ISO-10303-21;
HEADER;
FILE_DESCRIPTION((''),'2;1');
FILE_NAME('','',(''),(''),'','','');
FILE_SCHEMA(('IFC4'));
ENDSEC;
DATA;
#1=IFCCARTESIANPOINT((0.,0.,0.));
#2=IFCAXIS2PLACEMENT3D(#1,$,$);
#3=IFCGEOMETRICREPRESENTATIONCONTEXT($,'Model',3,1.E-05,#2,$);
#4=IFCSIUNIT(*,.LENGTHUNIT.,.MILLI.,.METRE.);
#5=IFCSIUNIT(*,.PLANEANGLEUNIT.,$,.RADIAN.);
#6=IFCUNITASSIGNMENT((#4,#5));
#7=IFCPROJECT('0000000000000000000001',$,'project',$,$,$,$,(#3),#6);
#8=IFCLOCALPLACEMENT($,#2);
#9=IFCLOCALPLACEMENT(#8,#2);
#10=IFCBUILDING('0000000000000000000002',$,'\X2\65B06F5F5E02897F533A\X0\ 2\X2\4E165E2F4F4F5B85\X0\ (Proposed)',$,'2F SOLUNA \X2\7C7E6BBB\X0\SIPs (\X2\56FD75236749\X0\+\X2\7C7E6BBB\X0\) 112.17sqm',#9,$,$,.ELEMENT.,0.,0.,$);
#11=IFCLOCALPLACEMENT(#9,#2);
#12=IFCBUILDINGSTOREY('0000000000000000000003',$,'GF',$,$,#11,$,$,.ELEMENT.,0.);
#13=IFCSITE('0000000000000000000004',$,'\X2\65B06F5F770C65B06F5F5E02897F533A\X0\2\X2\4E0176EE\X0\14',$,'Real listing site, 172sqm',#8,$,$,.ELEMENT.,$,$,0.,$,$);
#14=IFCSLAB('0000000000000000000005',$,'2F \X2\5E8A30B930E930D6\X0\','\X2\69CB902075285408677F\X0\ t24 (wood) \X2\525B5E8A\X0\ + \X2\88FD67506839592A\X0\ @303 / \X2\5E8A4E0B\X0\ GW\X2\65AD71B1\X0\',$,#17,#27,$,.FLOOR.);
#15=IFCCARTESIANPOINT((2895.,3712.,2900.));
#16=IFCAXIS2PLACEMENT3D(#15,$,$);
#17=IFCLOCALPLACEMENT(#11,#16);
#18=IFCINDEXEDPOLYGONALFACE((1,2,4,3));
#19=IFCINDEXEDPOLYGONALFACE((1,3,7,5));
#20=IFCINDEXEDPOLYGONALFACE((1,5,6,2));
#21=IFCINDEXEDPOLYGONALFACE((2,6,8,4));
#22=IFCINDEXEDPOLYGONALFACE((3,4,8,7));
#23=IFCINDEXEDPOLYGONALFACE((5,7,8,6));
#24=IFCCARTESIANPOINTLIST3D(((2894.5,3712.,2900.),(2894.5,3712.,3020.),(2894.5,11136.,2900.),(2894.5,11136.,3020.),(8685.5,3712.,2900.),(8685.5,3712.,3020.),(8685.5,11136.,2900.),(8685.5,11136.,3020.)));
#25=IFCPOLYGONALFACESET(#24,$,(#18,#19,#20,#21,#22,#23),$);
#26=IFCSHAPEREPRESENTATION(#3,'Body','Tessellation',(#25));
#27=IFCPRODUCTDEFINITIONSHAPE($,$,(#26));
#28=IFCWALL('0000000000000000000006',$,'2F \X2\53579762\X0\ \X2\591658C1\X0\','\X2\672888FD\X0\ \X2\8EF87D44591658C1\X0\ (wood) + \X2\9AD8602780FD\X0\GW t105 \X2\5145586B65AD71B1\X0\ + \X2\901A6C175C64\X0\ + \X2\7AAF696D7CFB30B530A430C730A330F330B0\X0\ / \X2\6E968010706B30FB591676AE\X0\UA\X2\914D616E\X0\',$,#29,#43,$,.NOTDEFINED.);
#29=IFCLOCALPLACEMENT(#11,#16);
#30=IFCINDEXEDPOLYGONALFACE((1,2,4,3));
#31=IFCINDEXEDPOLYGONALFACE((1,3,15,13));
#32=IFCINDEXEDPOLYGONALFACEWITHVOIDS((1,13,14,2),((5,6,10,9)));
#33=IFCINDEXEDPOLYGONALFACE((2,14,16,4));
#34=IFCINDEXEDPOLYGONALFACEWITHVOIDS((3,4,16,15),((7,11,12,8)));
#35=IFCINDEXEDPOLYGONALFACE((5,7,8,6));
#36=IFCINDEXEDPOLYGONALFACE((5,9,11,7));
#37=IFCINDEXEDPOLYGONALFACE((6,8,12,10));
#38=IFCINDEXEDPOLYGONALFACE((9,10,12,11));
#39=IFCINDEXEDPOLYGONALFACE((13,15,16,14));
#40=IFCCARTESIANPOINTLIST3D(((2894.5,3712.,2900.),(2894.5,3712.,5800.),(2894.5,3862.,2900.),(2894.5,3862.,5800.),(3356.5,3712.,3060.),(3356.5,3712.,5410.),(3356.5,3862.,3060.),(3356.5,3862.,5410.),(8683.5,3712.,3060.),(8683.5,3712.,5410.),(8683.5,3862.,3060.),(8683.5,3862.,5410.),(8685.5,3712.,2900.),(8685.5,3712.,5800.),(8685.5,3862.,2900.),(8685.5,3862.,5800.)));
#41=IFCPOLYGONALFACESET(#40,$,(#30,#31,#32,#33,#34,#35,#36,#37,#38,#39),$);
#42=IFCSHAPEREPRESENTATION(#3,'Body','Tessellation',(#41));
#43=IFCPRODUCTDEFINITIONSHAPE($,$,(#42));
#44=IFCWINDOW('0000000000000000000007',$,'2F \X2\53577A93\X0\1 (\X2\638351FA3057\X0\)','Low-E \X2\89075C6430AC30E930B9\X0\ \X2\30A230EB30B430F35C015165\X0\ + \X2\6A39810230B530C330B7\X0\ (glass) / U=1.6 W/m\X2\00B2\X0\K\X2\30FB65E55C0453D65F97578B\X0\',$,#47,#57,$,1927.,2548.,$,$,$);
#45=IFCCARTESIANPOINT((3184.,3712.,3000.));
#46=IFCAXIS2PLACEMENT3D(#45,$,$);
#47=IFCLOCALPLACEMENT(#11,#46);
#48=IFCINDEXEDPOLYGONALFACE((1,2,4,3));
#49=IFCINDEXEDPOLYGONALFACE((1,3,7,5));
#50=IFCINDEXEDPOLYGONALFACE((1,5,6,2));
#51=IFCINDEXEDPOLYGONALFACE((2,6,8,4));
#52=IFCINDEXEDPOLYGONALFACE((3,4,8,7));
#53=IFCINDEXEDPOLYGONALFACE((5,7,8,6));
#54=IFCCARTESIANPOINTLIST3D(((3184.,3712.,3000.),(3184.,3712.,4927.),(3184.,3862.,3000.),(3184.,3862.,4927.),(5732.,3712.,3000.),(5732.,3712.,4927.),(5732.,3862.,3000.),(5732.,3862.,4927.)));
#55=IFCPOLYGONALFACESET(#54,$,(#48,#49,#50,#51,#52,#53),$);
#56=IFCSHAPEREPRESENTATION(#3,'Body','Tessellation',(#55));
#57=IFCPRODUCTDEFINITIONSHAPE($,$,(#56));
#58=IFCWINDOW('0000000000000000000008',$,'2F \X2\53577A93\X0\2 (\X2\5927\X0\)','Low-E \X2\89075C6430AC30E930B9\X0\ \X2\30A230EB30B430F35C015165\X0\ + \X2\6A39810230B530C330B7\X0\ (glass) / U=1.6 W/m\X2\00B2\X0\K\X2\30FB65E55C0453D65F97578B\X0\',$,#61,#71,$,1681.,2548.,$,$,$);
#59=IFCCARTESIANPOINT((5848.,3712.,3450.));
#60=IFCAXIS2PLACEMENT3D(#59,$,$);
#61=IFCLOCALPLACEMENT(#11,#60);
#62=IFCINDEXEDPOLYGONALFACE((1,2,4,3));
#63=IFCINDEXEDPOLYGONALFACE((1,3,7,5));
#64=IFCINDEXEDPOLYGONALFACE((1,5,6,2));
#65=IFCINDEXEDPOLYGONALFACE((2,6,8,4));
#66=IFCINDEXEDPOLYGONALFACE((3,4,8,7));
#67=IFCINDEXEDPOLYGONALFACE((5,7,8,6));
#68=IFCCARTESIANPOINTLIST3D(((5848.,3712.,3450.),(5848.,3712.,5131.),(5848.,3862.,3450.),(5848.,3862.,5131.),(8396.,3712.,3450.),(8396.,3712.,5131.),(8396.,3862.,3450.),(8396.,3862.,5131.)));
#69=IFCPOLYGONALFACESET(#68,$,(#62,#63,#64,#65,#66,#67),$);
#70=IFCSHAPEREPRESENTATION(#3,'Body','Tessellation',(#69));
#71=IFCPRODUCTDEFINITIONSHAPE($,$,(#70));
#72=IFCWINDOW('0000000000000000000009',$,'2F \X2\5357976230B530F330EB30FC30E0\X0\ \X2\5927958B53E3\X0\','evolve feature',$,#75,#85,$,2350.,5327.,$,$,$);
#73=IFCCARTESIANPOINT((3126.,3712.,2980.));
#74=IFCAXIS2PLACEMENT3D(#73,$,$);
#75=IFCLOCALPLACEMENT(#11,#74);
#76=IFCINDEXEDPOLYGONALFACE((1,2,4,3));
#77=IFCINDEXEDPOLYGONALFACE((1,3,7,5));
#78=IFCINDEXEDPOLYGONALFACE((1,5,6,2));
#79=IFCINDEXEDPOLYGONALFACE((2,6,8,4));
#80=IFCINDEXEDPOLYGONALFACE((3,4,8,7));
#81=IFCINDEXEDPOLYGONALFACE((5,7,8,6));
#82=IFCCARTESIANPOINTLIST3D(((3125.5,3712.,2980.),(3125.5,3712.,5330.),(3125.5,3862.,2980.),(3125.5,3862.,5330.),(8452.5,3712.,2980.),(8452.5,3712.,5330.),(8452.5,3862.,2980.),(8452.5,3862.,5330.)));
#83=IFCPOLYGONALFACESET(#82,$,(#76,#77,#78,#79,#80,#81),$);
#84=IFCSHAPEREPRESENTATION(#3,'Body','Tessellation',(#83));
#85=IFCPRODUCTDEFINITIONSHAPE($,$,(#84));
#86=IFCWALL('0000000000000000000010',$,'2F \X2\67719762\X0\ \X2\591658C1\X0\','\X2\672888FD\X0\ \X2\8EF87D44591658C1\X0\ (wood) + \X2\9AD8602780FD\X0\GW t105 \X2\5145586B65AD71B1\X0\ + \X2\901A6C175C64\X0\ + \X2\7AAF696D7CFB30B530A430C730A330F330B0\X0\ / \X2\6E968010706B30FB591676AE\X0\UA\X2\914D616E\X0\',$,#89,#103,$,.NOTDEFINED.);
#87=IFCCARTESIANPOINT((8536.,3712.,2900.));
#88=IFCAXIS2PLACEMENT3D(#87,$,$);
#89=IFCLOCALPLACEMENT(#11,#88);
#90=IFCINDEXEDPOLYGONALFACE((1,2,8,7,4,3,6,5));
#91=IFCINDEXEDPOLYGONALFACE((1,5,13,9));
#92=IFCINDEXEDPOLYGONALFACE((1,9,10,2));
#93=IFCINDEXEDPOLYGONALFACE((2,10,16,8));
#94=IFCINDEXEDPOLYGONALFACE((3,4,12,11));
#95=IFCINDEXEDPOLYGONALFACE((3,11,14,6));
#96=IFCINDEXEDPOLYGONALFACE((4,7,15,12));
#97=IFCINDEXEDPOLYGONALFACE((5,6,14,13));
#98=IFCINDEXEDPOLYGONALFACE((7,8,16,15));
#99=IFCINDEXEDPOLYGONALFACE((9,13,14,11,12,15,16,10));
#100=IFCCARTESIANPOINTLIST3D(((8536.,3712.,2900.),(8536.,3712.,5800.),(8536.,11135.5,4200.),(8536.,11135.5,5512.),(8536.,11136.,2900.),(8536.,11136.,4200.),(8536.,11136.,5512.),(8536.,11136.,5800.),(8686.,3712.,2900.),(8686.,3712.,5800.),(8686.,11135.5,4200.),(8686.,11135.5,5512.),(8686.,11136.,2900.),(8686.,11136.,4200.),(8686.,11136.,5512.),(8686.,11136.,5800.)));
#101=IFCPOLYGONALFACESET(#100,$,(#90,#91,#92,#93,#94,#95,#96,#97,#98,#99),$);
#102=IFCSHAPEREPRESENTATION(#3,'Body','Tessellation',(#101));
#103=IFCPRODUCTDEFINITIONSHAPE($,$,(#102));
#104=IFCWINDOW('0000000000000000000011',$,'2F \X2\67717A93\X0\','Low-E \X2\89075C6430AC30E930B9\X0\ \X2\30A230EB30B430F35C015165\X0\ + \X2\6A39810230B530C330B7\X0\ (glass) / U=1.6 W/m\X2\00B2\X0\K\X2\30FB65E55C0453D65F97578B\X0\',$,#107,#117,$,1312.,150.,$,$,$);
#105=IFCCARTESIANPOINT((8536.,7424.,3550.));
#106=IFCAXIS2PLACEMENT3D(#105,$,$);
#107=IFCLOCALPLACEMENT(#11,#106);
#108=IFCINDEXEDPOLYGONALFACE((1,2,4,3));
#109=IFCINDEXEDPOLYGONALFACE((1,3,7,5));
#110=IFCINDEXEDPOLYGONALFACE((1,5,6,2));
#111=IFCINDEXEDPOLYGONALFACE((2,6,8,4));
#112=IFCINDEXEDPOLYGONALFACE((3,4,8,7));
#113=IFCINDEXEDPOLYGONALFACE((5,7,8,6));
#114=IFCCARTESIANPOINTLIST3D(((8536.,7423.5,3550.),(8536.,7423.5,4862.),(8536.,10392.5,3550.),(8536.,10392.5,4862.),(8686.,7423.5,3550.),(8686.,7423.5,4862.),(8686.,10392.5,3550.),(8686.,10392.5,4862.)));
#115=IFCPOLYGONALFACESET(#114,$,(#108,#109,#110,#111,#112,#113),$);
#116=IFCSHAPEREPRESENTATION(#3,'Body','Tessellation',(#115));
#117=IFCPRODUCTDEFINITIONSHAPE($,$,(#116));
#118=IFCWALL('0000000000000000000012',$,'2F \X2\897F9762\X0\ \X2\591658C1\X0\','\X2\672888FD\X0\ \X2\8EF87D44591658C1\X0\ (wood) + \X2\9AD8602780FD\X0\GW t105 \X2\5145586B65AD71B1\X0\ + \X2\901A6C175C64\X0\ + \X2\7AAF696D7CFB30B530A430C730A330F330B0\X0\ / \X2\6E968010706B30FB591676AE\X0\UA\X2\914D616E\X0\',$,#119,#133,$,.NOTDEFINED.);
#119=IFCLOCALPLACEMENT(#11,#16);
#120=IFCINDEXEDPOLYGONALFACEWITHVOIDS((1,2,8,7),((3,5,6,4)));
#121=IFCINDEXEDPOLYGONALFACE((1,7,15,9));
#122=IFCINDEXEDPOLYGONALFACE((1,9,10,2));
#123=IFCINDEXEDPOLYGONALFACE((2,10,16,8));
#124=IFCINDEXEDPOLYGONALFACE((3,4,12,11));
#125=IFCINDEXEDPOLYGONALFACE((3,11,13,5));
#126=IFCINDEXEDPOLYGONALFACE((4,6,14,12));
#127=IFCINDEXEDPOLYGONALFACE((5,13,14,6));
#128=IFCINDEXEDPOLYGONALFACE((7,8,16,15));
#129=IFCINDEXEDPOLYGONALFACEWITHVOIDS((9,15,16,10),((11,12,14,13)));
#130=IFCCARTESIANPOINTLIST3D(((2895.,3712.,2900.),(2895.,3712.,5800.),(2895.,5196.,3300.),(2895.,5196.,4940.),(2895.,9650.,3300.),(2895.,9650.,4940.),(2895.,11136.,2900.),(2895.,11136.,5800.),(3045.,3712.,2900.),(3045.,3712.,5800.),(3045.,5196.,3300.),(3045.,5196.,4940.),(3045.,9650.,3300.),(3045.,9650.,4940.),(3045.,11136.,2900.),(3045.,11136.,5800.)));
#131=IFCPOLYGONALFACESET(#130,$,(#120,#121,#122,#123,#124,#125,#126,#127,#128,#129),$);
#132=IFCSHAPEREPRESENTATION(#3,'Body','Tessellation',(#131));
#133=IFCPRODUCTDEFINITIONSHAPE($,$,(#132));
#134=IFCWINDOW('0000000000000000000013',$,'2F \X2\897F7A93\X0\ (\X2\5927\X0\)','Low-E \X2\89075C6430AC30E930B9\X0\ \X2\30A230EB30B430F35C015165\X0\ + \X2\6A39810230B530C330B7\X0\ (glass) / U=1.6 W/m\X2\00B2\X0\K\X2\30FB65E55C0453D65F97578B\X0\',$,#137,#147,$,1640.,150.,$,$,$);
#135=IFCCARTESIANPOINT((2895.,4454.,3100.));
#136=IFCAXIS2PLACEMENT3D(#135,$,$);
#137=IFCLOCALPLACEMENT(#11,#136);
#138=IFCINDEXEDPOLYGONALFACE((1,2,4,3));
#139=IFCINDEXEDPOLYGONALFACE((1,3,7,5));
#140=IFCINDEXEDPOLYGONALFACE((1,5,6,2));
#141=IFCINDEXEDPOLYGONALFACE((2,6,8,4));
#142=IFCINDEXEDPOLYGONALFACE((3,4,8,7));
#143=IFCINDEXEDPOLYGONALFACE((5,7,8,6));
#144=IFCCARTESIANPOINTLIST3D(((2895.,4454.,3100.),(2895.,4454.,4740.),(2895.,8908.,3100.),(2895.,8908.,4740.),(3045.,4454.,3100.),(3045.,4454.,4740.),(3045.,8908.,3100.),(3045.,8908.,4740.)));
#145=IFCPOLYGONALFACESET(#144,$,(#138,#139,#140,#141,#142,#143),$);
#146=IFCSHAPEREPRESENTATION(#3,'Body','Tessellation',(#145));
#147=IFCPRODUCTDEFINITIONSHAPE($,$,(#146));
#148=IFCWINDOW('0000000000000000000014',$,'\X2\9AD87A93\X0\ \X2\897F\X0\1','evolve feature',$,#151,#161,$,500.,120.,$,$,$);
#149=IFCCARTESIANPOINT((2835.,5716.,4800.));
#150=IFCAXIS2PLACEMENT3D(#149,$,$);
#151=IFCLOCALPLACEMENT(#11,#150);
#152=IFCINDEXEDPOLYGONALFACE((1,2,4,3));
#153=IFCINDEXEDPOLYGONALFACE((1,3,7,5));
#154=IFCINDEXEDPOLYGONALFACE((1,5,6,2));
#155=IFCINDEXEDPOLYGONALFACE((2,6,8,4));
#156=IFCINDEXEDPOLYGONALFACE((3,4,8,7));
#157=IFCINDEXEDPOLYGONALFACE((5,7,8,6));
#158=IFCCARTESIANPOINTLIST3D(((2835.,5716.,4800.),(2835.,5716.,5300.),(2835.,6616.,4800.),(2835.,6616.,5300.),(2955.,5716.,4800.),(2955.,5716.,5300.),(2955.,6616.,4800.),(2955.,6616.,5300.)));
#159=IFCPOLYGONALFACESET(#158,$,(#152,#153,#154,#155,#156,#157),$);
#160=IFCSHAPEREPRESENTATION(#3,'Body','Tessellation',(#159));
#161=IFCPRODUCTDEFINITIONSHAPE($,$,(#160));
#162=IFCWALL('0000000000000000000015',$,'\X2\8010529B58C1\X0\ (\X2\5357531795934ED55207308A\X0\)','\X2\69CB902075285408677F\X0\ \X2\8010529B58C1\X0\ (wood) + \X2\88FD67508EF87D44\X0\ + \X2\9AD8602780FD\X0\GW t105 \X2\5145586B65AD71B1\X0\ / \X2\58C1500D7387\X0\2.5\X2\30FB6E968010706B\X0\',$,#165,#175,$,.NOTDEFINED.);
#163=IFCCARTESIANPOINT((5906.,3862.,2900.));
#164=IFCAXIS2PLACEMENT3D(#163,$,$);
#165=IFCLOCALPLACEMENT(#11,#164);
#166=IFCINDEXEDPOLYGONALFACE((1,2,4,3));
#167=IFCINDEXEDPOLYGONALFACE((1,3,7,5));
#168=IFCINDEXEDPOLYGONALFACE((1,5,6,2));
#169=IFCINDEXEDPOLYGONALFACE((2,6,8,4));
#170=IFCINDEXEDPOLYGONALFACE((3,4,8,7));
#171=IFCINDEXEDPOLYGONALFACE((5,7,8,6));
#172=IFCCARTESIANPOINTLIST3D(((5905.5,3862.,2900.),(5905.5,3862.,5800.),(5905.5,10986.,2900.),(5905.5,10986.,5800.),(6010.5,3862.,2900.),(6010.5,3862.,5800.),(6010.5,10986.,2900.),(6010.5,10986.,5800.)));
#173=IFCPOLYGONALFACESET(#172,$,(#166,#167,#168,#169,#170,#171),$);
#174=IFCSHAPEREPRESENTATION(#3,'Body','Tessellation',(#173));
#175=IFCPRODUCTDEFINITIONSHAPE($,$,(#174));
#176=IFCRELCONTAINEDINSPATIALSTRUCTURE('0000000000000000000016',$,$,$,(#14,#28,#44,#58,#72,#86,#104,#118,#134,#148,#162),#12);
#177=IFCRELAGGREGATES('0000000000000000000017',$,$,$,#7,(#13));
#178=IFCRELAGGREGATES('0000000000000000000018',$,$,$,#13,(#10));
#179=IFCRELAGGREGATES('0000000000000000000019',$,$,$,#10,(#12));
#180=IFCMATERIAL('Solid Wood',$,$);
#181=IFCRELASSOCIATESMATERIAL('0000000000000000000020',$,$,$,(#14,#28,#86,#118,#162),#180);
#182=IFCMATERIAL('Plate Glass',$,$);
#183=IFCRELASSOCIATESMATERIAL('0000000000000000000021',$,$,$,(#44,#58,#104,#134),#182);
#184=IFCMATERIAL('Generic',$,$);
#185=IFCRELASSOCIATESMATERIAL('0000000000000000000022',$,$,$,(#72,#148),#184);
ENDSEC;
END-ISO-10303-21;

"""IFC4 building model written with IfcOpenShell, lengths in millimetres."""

from ifc_helpers import new_model, si_unit, frame, frame_2d, origin, place, context, project, spatial, rectangle, extrude, material, element, fill, save


model = new_model("IFC4")

# Units and contexts
model_context = context("Model", 3, precision=1e-05, world=origin())
ifc_project = project(units=[si_unit("LENGTHUNIT", "METRE", prefix="MILLI"), si_unit("PLANEANGLEUNIT", "RADIAN")], contexts=[model_context])

# Site, building, storey
site_placement = place(None, origin())
site = spatial("IfcSite", under=ifc_project, at=site_placement, Name="新潟県新潟市西区2丁目14", ObjectType="Real listing site, 172sqm", CompositionType="ELEMENT", RefElevation=0.0)
building_placement = place(site_placement, origin())
building = spatial("IfcBuilding", under=site, at=building_placement, Name="新潟市西区 2世帯住宅 (Proposed)", ObjectType="2F SOLUNA 籾殻SIPs (国産杉+籾殻) 112.17sqm", CompositionType="ELEMENT", ElevationOfRefHeight=0.0, ElevationOfTerrain=0.0)
storey_placement = place(building_placement, origin())
storey = spatial("IfcBuildingStorey", under=building, at=storey_placement, Name="GF", CompositionType="ELEMENT", Elevation=0.0)

# Slab
ifc_material_1 = material(Name="Solid Wood")
slab_placement = place(storey_placement, frame((2895.0, 3712.0, 2900.0)))
element("IfcSlab", 1, at=slab_placement, inside=storey, material=ifc_material_1, Name="2F 床スラブ", Description="構造用合板 t24 (wood) 剛床 + 製材根太 @303 / 床下 GW断熱", PredefinedType="FLOOR", context=model_context, shape_type="SweptSolid", body=[
    extrude(rectangle(XDim=5791.0, YDim=7424.0, at=frame_2d((2895.0, 3712.0))), frame((2895.0, 3712.0, 2900.0)), (0.0, 0.0, 1.0), 120.0),
])

# Wall, openings, windows
wall_1_placement = place(storey_placement, frame((2895.0, 3712.0, 2900.0)))
wall_1 = element("IfcWall", 2, at=wall_1_placement, inside=storey, material=ifc_material_1, Name="2F 南面 外壁", Description="木製 軸組外壁 (wood) + 高性能GW t105 充填断熱 + 通気層 + 窯業系サイディング / 準耐火・外皮UA配慮", PredefinedType="NOTDEFINED", context=model_context, shape_type="SweptSolid", body=[
    extrude(rectangle(XDim=5791.0, YDim=150.0, at=frame_2d((2895.0, 75.0))), frame((2895.0, 3712.0, 2900.0)), (0.0, 0.0, 1.0), 2900.0),
])
opening_1_placement = place(storey_placement, frame((3184.0, 3712.0, 3000.0)))
opening_1 = element("IfcOpeningElement", 3, at=opening_1_placement, cuts=wall_1, PredefinedType="NOTDEFINED", context=model_context, shape_type="SweptSolid", body=[
    extrude(rectangle(XDim=2548.0, YDim=150.0, at=frame_2d((1274.0, 75.0))), frame((3184.0, 3712.0, 3000.0)), (0.0, 0.0, 1.0), 1927.0),
])
opening_2_placement = place(storey_placement, frame((5848.0, 3712.0, 3450.0)))
opening_2 = element("IfcOpeningElement", 4, at=opening_2_placement, cuts=wall_1, PredefinedType="NOTDEFINED", context=model_context, shape_type="SweptSolid", body=[
    extrude(rectangle(XDim=2548.0, YDim=150.0, at=frame_2d((1274.0, 75.0))), frame((5848.0, 3712.0, 3450.0)), (0.0, 0.0, 1.0), 1681.0),
])
opening_3_placement = place(storey_placement, frame((3126.0, 3712.0, 2980.0)))
opening_3 = element("IfcOpeningElement", 5, at=opening_3_placement, cuts=wall_1, PredefinedType="NOTDEFINED", context=model_context, shape_type="SweptSolid", body=[
    extrude(rectangle(XDim=5327.0, YDim=150.0, at=frame_2d((2663.0, 75.0))), frame((3126.0, 3712.0, 2980.0)), (0.0, 0.0, 1.0), 2350.0),
])
ifc_material_2 = material(Name="Plate Glass")
window_1_placement = place(storey_placement, frame((3184.0, 3712.0, 3000.0)))
window_1 = element("IfcWindow", 6, at=window_1_placement, inside=storey, material=ifc_material_2, Name="2F 南窓1 (掃出し)", Description="Low-E 複層ガラス アルゴン封入 + 樹脂サッシ (glass) / U=1.6 W/m²K・日射取得型", OverallHeight=1927.0, OverallWidth=2548.0, context=model_context, shape_type="SweptSolid", body=[
    extrude(rectangle(XDim=2548.0, YDim=150.0, at=frame_2d((1274.0, 75.0))), frame((3184.0, 3712.0, 3000.0)), (0.0, 0.0, 1.0), 1927.0),
])
fill(opening_1, window_1)
window_2_placement = place(storey_placement, frame((5848.0, 3712.0, 3450.0)))
window_2 = element("IfcWindow", 7, at=window_2_placement, inside=storey, material=ifc_material_2, Name="2F 南窓2 (大)", Description="Low-E 複層ガラス アルゴン封入 + 樹脂サッシ (glass) / U=1.6 W/m²K・日射取得型", OverallHeight=1681.0, OverallWidth=2548.0, context=model_context, shape_type="SweptSolid", body=[
    extrude(rectangle(XDim=2548.0, YDim=150.0, at=frame_2d((1274.0, 75.0))), frame((5848.0, 3712.0, 3450.0)), (0.0, 0.0, 1.0), 1681.0),
])
fill(opening_2, window_2)
ifc_material_3 = material(Name="Generic")
window_3_placement = place(storey_placement, frame((3126.0, 3712.0, 2980.0)))
window_3 = element("IfcWindow", 8, at=window_3_placement, inside=storey, material=ifc_material_3, Name="2F 南面サンルーム 大開口", Description="evolve feature", OverallHeight=2350.0, OverallWidth=5327.0, context=model_context, shape_type="SweptSolid", body=[
    extrude(rectangle(XDim=5327.0, YDim=150.0, at=frame_2d((2663.0, 75.0))), frame((3126.0, 3712.0, 2980.0)), (0.0, 0.0, 1.0), 2350.0),
])
fill(opening_3, window_3)

# Wall, opening, window
wall_2_placement = place(storey_placement, frame((8536.0, 3712.0, 2900.0)))
wall_2 = element("IfcWall", 9, at=wall_2_placement, inside=storey, material=ifc_material_1, Name="2F 東面 外壁", Description="木製 軸組外壁 (wood) + 高性能GW t105 充填断熱 + 通気層 + 窯業系サイディング / 準耐火・外皮UA配慮", PredefinedType="NOTDEFINED", context=model_context, shape_type="SweptSolid", body=[
    extrude(rectangle(XDim=150.0, YDim=7424.0, at=frame_2d((75.0, 3712.0))), frame((8536.0, 3712.0, 2900.0)), (0.0, 0.0, 1.0), 2900.0),
])
opening_4_placement = place(storey_placement, frame((8536.0, 7424.0, 3550.0)))
opening_4 = element("IfcOpeningElement", 10, at=opening_4_placement, cuts=wall_2, PredefinedType="NOTDEFINED", context=model_context, shape_type="SweptSolid", body=[
    extrude(rectangle(XDim=150.0, YDim=2969.0, at=frame_2d((75.0, 1484.0))), frame((8536.0, 7424.0, 3550.0)), (0.0, 0.0, 1.0), 1312.0),
])
window_4_placement = place(storey_placement, frame((8536.0, 7424.0, 3550.0)))
window_4 = element("IfcWindow", 11, at=window_4_placement, inside=storey, material=ifc_material_2, Name="2F 東窓", Description="Low-E 複層ガラス アルゴン封入 + 樹脂サッシ (glass) / U=1.6 W/m²K・日射取得型", OverallHeight=1312.0, OverallWidth=150.0, context=model_context, shape_type="SweptSolid", body=[
    extrude(rectangle(XDim=150.0, YDim=2969.0, at=frame_2d((75.0, 1484.0))), frame((8536.0, 7424.0, 3550.0)), (0.0, 0.0, 1.0), 1312.0),
])
fill(opening_4, window_4)

# Wall, openings, windows
wall_3_placement = place(storey_placement, frame((2895.0, 3712.0, 2900.0)))
wall_3 = element("IfcWall", 12, at=wall_3_placement, inside=storey, material=ifc_material_1, Name="2F 西面 外壁", Description="木製 軸組外壁 (wood) + 高性能GW t105 充填断熱 + 通気層 + 窯業系サイディング / 準耐火・外皮UA配慮", PredefinedType="NOTDEFINED", context=model_context, shape_type="SweptSolid", body=[
    extrude(rectangle(XDim=150.0, YDim=7424.0, at=frame_2d((75.0, 3712.0))), frame((2895.0, 3712.0, 2900.0)), (0.0, 0.0, 1.0), 2900.0),
])
opening_5_placement = place(storey_placement, frame((2895.0, 4454.0, 3100.0)))
opening_5 = element("IfcOpeningElement", 13, at=opening_5_placement, cuts=wall_3, PredefinedType="NOTDEFINED", context=model_context, shape_type="SweptSolid", body=[
    extrude(rectangle(XDim=150.0, YDim=4454.0, at=frame_2d((75.0, 2227.0))), frame((2895.0, 4454.0, 3100.0)), (0.0, 0.0, 1.0), 1640.0),
])
opening_6_placement = place(storey_placement, frame((2835.0, 5716.0, 4800.0)))
opening_6 = element("IfcOpeningElement", 14, at=opening_6_placement, cuts=wall_3, PredefinedType="NOTDEFINED", context=model_context, shape_type="SweptSolid", body=[
    extrude(rectangle(XDim=120.0, YDim=900.0, at=frame_2d((60.0, 450.0))), frame((2835.0, 5716.0, 4800.0)), (0.0, 0.0, 1.0), 500.0),
])
window_5_placement = place(storey_placement, frame((2895.0, 4454.0, 3100.0)))
window_5 = element("IfcWindow", 15, at=window_5_placement, inside=storey, material=ifc_material_2, Name="2F 西窓 (大)", Description="Low-E 複層ガラス アルゴン封入 + 樹脂サッシ (glass) / U=1.6 W/m²K・日射取得型", OverallHeight=1640.0, OverallWidth=150.0, context=model_context, shape_type="SweptSolid", body=[
    extrude(rectangle(XDim=150.0, YDim=4454.0, at=frame_2d((75.0, 2227.0))), frame((2895.0, 4454.0, 3100.0)), (0.0, 0.0, 1.0), 1640.0),
])
fill(opening_5, window_5)
window_6_placement = place(storey_placement, frame((2835.0, 5716.0, 4800.0)))
window_6 = element("IfcWindow", 16, at=window_6_placement, inside=storey, material=ifc_material_3, Name="高窓 西1", Description="evolve feature", OverallHeight=500.0, OverallWidth=120.0, context=model_context, shape_type="SweptSolid", body=[
    extrude(rectangle(XDim=120.0, YDim=900.0, at=frame_2d((60.0, 450.0))), frame((2835.0, 5716.0, 4800.0)), (0.0, 0.0, 1.0), 500.0),
])
fill(opening_6, window_6)

# Wall
wall_4_placement = place(storey_placement, frame((5906.0, 3862.0, 2900.0)))
element("IfcWall", 17, at=wall_4_placement, inside=storey, material=ifc_material_1, Name="耐力壁 (南北間仕切り)", Description="構造用合板 耐力壁 (wood) + 製材軸組 + 高性能GW t105 充填断熱 / 壁倍率2.5・準耐火", PredefinedType="NOTDEFINED", context=model_context, shape_type="SweptSolid", body=[
    extrude(rectangle(XDim=105.0, YDim=7124.0, at=frame_2d((52.0, 3562.0))), frame((5906.0, 3862.0, 2900.0)), (0.0, 0.0, 1.0), 2900.0),
])

save(model, "model.ifc")
